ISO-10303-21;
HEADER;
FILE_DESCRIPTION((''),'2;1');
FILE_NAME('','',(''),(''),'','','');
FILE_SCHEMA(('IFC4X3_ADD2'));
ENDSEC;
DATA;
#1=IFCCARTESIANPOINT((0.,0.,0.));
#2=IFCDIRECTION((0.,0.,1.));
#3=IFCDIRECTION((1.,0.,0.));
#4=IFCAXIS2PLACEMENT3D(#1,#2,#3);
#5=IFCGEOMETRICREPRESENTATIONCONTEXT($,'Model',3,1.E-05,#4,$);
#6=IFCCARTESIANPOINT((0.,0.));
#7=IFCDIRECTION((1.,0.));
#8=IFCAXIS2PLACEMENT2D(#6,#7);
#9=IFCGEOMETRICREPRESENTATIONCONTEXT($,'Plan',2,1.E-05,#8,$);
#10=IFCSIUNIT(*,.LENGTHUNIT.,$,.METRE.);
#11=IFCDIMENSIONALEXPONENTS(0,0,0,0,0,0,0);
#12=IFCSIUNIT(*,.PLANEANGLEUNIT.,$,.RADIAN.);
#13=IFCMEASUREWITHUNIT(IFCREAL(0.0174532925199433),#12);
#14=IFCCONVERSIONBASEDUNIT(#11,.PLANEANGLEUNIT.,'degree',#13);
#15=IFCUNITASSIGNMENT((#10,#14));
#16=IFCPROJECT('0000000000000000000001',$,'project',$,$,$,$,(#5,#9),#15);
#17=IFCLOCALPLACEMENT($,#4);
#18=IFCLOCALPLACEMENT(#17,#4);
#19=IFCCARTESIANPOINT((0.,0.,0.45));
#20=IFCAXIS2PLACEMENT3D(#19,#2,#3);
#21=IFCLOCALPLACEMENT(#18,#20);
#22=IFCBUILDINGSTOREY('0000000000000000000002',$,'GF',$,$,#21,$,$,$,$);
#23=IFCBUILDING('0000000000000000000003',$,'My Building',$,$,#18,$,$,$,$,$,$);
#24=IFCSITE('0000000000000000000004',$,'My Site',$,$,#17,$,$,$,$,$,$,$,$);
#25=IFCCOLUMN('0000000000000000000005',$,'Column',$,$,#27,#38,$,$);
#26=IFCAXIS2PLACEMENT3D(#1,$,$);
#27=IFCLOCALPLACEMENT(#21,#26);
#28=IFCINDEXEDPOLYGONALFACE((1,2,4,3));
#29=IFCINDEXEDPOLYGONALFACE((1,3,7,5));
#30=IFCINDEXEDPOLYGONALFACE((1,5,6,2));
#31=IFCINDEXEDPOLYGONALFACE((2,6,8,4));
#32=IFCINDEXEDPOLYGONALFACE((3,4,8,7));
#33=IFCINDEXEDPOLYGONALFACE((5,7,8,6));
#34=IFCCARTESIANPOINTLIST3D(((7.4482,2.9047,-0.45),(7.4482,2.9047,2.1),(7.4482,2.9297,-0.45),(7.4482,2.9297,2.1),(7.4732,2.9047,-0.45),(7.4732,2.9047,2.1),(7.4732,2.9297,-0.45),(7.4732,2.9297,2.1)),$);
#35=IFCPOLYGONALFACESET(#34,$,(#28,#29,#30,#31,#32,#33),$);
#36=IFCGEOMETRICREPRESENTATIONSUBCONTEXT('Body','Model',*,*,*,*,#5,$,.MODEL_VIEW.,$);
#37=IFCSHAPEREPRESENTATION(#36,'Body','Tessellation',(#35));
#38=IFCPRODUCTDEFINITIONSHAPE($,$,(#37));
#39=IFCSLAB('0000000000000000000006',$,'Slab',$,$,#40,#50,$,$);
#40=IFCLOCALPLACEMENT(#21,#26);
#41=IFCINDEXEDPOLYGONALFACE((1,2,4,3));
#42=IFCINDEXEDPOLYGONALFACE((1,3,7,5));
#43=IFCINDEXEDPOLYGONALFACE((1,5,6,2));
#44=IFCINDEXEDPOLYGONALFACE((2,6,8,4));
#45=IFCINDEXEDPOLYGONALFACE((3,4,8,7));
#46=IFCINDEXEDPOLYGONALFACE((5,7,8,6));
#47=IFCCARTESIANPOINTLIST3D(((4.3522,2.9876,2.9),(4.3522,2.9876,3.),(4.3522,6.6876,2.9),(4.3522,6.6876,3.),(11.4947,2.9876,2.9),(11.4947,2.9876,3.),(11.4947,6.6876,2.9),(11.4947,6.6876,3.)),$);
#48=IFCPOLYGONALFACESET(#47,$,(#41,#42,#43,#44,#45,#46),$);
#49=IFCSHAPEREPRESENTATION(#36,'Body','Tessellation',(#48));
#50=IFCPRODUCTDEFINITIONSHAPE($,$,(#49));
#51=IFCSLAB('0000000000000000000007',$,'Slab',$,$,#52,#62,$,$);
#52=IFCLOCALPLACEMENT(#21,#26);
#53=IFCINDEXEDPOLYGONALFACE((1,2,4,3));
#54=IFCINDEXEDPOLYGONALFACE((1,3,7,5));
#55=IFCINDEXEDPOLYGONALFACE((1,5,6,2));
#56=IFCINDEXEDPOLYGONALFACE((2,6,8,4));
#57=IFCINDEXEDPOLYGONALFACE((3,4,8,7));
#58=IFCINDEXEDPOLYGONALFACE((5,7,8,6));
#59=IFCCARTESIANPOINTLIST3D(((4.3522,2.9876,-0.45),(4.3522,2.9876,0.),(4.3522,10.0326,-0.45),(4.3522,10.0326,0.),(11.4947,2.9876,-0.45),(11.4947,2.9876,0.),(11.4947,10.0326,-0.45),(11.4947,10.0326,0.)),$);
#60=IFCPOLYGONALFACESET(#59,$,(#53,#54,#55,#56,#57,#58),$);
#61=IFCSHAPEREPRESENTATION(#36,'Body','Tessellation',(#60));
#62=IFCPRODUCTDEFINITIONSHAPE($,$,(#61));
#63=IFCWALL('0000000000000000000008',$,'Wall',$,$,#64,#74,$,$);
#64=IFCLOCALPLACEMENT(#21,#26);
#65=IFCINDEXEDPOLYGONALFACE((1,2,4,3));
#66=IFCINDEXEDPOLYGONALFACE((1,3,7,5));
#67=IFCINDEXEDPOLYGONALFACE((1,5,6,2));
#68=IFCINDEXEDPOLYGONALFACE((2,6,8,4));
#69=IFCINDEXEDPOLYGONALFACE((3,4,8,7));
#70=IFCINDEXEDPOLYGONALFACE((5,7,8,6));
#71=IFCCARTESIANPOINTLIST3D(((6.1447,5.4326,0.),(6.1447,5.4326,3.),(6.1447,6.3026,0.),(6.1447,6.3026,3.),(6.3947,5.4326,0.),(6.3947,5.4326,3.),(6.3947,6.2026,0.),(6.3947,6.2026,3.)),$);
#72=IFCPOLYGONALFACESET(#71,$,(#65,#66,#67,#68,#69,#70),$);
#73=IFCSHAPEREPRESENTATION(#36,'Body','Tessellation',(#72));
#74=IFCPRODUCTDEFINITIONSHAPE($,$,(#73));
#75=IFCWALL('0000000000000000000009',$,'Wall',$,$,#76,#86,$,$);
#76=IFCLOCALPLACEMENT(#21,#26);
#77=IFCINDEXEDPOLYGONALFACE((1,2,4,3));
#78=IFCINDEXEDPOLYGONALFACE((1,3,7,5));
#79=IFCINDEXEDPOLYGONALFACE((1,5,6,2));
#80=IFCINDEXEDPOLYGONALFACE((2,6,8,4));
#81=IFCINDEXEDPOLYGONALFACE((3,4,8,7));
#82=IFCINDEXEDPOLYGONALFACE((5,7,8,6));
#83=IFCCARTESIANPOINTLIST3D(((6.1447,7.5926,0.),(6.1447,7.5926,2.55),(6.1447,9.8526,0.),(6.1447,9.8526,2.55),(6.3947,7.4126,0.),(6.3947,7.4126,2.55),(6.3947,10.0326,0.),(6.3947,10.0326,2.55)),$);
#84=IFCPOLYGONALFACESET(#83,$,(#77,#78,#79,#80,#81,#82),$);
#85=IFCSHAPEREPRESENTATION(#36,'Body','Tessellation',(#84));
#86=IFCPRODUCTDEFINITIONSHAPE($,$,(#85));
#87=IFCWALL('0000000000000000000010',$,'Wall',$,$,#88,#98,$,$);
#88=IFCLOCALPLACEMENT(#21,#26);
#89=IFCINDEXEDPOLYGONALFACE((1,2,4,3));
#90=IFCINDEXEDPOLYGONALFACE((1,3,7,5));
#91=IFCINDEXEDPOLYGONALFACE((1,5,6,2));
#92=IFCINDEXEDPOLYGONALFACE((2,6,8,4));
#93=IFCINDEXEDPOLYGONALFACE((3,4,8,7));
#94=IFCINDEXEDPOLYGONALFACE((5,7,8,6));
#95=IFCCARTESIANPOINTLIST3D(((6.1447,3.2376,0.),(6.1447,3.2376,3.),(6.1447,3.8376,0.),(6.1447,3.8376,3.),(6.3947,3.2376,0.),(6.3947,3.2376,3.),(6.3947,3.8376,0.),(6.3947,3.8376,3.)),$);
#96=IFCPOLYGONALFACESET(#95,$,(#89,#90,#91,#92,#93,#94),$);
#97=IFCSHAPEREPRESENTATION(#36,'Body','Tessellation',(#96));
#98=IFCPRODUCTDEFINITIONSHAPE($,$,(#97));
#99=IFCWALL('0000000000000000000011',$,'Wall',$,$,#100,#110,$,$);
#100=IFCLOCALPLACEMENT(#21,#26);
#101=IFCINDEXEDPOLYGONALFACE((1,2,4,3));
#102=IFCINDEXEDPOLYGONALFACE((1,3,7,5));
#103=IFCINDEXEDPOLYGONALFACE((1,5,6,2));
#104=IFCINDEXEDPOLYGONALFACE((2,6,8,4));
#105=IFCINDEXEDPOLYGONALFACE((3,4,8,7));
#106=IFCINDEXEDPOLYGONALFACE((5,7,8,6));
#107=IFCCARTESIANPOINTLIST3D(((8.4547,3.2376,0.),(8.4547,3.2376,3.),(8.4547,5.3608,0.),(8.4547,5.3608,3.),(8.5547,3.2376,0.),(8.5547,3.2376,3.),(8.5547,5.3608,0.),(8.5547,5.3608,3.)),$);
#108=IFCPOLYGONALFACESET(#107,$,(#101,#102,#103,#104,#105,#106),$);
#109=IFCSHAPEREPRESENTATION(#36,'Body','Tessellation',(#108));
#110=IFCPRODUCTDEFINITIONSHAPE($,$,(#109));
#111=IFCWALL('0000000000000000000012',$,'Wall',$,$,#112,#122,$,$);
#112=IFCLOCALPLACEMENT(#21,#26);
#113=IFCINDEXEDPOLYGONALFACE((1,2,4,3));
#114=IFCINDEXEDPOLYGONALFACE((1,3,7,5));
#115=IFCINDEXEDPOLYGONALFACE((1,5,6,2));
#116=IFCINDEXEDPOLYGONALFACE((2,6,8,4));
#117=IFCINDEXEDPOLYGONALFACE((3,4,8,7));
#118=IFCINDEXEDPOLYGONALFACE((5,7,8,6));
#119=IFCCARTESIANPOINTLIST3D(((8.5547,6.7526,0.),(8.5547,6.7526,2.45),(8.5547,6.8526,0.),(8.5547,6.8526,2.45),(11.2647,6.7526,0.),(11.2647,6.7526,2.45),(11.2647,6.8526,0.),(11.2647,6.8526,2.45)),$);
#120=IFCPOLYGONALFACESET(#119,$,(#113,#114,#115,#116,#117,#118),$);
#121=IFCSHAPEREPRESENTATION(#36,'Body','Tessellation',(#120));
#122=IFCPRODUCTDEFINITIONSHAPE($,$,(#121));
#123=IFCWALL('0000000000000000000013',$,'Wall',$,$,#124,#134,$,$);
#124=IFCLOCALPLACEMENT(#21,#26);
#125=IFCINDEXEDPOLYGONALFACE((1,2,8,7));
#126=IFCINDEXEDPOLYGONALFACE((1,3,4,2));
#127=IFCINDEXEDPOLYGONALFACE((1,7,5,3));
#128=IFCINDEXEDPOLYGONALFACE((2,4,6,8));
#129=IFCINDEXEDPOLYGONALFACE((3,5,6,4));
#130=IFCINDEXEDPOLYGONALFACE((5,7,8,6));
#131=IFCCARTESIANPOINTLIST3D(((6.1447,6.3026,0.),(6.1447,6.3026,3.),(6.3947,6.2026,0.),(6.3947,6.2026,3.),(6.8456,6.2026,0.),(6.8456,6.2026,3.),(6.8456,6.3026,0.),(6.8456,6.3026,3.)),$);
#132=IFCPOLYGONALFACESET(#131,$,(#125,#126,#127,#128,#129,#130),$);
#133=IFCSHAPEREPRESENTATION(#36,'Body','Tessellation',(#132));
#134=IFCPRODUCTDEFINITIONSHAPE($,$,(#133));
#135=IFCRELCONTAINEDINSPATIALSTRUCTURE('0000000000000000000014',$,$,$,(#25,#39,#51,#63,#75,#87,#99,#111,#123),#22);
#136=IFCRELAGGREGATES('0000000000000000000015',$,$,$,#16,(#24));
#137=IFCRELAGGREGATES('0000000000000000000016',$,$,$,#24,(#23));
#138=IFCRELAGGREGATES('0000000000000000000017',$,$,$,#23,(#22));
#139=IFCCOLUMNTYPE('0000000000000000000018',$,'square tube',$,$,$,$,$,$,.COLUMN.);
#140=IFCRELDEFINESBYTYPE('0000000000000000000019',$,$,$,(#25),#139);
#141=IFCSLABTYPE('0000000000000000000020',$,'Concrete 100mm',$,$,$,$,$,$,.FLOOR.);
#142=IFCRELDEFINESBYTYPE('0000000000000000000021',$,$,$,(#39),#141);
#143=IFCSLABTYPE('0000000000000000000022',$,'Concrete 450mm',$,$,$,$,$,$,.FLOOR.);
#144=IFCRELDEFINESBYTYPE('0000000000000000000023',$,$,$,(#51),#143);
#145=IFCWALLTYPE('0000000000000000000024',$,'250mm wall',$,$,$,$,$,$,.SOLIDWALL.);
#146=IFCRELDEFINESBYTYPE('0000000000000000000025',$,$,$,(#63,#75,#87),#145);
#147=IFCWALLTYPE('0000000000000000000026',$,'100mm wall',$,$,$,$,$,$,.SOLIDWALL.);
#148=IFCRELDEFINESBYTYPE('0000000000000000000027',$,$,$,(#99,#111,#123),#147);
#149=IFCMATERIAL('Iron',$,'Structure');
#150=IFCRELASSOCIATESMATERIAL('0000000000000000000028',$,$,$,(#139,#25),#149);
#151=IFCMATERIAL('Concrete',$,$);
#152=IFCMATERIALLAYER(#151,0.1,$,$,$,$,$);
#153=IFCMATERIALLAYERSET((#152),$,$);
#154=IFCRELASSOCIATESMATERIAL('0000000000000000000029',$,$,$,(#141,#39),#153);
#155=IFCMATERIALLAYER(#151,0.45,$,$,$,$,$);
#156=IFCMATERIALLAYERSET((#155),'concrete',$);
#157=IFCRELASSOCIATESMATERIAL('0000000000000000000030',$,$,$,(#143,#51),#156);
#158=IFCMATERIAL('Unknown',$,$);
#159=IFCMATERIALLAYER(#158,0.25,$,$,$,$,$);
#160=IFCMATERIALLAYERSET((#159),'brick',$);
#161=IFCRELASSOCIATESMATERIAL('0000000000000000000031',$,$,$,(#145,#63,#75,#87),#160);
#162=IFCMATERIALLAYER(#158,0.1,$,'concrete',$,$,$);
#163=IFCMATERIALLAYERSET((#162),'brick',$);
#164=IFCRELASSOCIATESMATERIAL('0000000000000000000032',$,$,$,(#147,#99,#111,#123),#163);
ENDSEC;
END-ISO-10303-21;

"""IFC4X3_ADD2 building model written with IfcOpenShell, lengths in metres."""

from ifc_helpers import new_model, entity, si_unit, converted_unit, frame, origin_with_axes, origin_2d_with_axis, place, context, subcontext, project, spatial, line, indexed_curve, outline, extrude, material, layer, layer_set, layer_usage, material_profile, profile_set, profile_usage, type_object, element, save


model = new_model("IFC4X3_ADD2")

# Units and contexts
model_context = context("Model", 3, precision=1e-05, world=origin_with_axes())
plan_context = context("Plan", 2, precision=1e-05, world=origin_2d_with_axis())
body_context_1 = subcontext(model_context, "Body", "Model", "MODEL_VIEW")
ifc_project = project(units=[si_unit("LENGTHUNIT", "METRE"), converted_unit("PLANEANGLEUNIT", "degree", entity("IfcReal", 0.0174532925199433), si_unit("PLANEANGLEUNIT", "RADIAN"), dimensions=[0, 0, 0, 0, 0, 0, 0])], contexts=[model_context, plan_context])

# Site, building, storey
site_placement = place(None, origin_with_axes())
site = spatial("IfcSite", under=ifc_project, at=site_placement, Name="My Site")
building_placement = place(site_placement, origin_with_axes())
building = spatial("IfcBuilding", under=site, at=building_placement, Name="My Building")
storey_placement = place(building_placement, frame((0.0, 0.0, 0.45), z_axis=(0.0, 0.0, 1.0), x_axis=(1.0, 0.0, 0.0)))
storey = spatial("IfcBuildingStorey", under=building, at=storey_placement, Name="GF")

# Column
ifc_material_1 = material(Name="Iron", Category="Structure")
ifc_material_profile = material_profile(ifc_material_1, outline(indexed_curve([(-0.0125, -0.0125), (0.0125, -0.0125), (0.0125, 0.0125), (-0.0125, 0.0125), (-0.0125, -0.0125)])))
ifc_profile_set = profile_set([ifc_material_profile])
ifc_profile_usage = profile_usage(ifc_profile_set, cardinal=5)
column_type = type_object("IfcColumnType", Name="square tube", PredefinedType="COLUMN", material=ifc_profile_set)
column_placement = place(storey_placement, frame((7.4607, 2.9172, -0.45), z_axis=(0.0, 0.0, 1.0), x_axis=(0.0, -1.0, 0.0)))
element("IfcColumn", 1, at=column_placement, inside=storey, type_object=column_type, material=ifc_profile_usage, Name="Column", context=body_context_1, shape_type="SweptSolid", body=[
    extrude(outline(indexed_curve([(-0.0125, -0.0125), (0.0125, -0.0125), (0.0125, 0.0125), (-0.0125, 0.0125), (-0.0125, -0.0125)])), origin_with_axes(), (0.0, 0.0, 1.0), 2.55),
])

# Slabs
ifc_material_2 = material(Name="Concrete")
ifc_layer_1 = layer(ifc_material_2, 0.1)
ifc_layer_set_1 = layer_set([ifc_layer_1])
slab_type_1 = type_object("IfcSlabType", Name="Concrete 100mm", PredefinedType="FLOOR", material=ifc_layer_set_1)
ifc_layer_usage_1 = layer_usage(ifc_layer_set_1, "AXIS3", "POSITIVE", 0.0)
slab_1_placement = place(storey_placement, frame((4.3522, 2.9876, 2.9), z_axis=(0.0, 0.0, 1.0), x_axis=(1.0, 0.0, 0.0)))
element("IfcSlab", 2, at=slab_1_placement, inside=storey, type_object=slab_type_1, material=ifc_layer_usage_1, Name="Slab", context=body_context_1, shape_type="SolidModel", body=[
    extrude(outline(indexed_curve([(0.0, 0.0), (7.1425, 0.0), (7.1425, 3.7), (0.0, 3.7), (0.0, 0.0)])), origin_with_axes(), (0.0, 0.0, 1.0), 0.1),
])
ifc_layer_2 = layer(ifc_material_2, 0.45)
ifc_layer_set_2 = layer_set([ifc_layer_2], Name="concrete")
ifc_layer_usage_2 = layer_usage(ifc_layer_set_2, "AXIS3", "POSITIVE", -0.45)
slab_type_2 = type_object("IfcSlabType", Name="Concrete 450mm", PredefinedType="FLOOR", material=ifc_layer_set_2)
slab_2_placement = place(storey_placement, frame((4.3522, 2.9876, 0.0), z_axis=(0.0, 0.0, 1.0), x_axis=(1.0, 0.0, 0.0)))
element("IfcSlab", 3, at=slab_2_placement, inside=storey, type_object=slab_type_2, material=ifc_layer_usage_2, Name="Slab", context=body_context_1, shape_type="SweptSolid", body=[
    extrude(outline(indexed_curve([(0.0, 0.0), (7.1425, 0.0), (7.1425, 7.045), (0.0, 7.045), (0.0, 0.0)])), frame((0.0, 0.0, -0.45), z_axis=(0.0, 0.0, 1.0), x_axis=(1.0, 0.0, 0.0)), (0.0, 0.0, 1.0), 0.45),
])

# Shared definitions
ifc_material_3 = material(Name="Unknown")
ifc_layer_3 = layer(ifc_material_3, 0.25)
ifc_layer_set_3 = layer_set([ifc_layer_3], Name="brick")
wall_type_1 = type_object("IfcWallType", Name="250mm wall", PredefinedType="SOLIDWALL", material=ifc_layer_set_3)

# Walls
ifc_layer_usage_3 = layer_usage(ifc_layer_set_3, "AXIS2", "POSITIVE", 0.0)
wall_1_placement = place(storey_placement, frame((6.3947, 5.4326, 0.0), z_axis=(0.0, 0.0, 1.0), x_axis=(0.0, 1.0, 0.0)))
element("IfcWall", 4, at=wall_1_placement, inside=storey, type_object=wall_type_1, material=ifc_layer_usage_3, Name="Wall", context=body_context_1, shape_type="SweptSolid", body=[
    extrude(outline(indexed_curve([(0.0, 0.0), (0.0, 0.25), (0.87, 0.25), (0.77, 0.0)], segments=[line(1, 2, 3, 4, 1)])), origin_with_axes(), (0.0, 0.0, 1.0), 3.0),
])
ifc_layer_usage_4 = layer_usage(ifc_layer_set_3, "AXIS2", "POSITIVE", 0.0)
wall_2_placement = place(storey_placement, frame((6.3947, 7.5926, 0.0), z_axis=(0.0, 0.0, 1.0), x_axis=(0.0, 1.0, 0.0)))
element("IfcWall", 5, at=wall_2_placement, inside=storey, type_object=wall_type_1, material=ifc_layer_usage_4, Name="Wall", context=body_context_1, shape_type="SweptSolid", body=[
    extrude(outline(indexed_curve([(-0.18, 0.0), (0.0, 0.25), (2.26, 0.25), (2.44, 0.0)], segments=[line(1, 2, 3, 4, 1)])), origin_with_axes(), (0.0, 0.0, 1.0), 2.55),
])
ifc_layer_usage_5 = layer_usage(ifc_layer_set_3, "AXIS2", "POSITIVE", 0.0)
wall_3_placement = place(storey_placement, frame((6.3947, 3.2376, 0.0), z_axis=(0.0, 0.0, 1.0), x_axis=(0.0, 1.0, 0.0)))
element("IfcWall", 6, at=wall_3_placement, inside=storey, type_object=wall_type_1, material=ifc_layer_usage_5, Name="Wall", context=body_context_1, shape_type="SweptSolid", body=[
    extrude(outline(indexed_curve([(0.0, 0.0), (0.0, 0.25), (0.6, 0.25), (0.6, 0.0), (0.0, 0.0)], self_intersect=False)), origin_with_axes(), (0.0, 0.0, 1.0), 3.0),
])
ifc_layer_4 = layer(ifc_material_3, 0.1, Name="concrete")
ifc_layer_set_4 = layer_set([ifc_layer_4], Name="brick")
ifc_layer_usage_6 = layer_usage(ifc_layer_set_4, "AXIS2", "POSITIVE", 0.0)
wall_type_2 = type_object("IfcWallType", Name="100mm wall", PredefinedType="SOLIDWALL", material=ifc_layer_set_4)
wall_4_placement = place(storey_placement, frame((8.5547, 3.2376, 0.0), z_axis=(0.0, 0.0, 1.0), x_axis=(0.0, 1.0, 0.0)))
element("IfcWall", 7, at=wall_4_placement, inside=storey, type_object=wall_type_2, material=ifc_layer_usage_6, Name="Wall", context=body_context_1, shape_type="SweptSolid", body=[
    extrude(outline(indexed_curve([(0.0, 0.0), (0.0, 0.1), (2.1232, 0.1), (2.1232, 0.0)], segments=[line(1, 2, 3, 4, 1)])), origin_with_axes(), (0.0, 0.0, 1.0), 3.0),
])
ifc_layer_usage_7 = layer_usage(ifc_layer_set_4, "AXIS2", "POSITIVE", 0.0)
wall_5_placement = place(storey_placement, frame((8.5547, 6.7526, 0.0), z_axis=(0.0, 0.0, 1.0), x_axis=(1.0, 0.0, 0.0)))
element("IfcWall", 8, at=wall_5_placement, inside=storey, type_object=wall_type_2, material=ifc_layer_usage_7, Name="Wall", context=body_context_1, shape_type="SweptSolid", body=[
    extrude(outline(indexed_curve([(0.0, 0.0), (0.0, 0.1), (2.71, 0.1), (2.71, 0.0)], segments=[line(1, 2, 3, 4, 1)])), origin_with_axes(), (0.0, 0.0, 1.0), 2.45),
])
ifc_layer_usage_8 = layer_usage(ifc_layer_set_4, "AXIS2", "POSITIVE", 0.0)
wall_6_placement = place(storey_placement, frame((6.3947, 6.2026, 0.0), z_axis=(0.0, 0.0, 1.0), x_axis=(1.0, 0.0, 0.0)))
element("IfcWall", 9, at=wall_6_placement, inside=storey, type_object=wall_type_2, material=ifc_layer_usage_8, Name="Wall", context=body_context_1, shape_type="SweptSolid", body=[
    extrude(outline(indexed_curve([(0.0, 0.0), (-0.25, 0.1), (0.451, 0.1), (0.451, 0.0)], segments=[line(1, 2, 3, 4, 1)])), origin_with_axes(), (0.0, 0.0, 1.0), 3.0),
])

save(model, "model.ifc")
